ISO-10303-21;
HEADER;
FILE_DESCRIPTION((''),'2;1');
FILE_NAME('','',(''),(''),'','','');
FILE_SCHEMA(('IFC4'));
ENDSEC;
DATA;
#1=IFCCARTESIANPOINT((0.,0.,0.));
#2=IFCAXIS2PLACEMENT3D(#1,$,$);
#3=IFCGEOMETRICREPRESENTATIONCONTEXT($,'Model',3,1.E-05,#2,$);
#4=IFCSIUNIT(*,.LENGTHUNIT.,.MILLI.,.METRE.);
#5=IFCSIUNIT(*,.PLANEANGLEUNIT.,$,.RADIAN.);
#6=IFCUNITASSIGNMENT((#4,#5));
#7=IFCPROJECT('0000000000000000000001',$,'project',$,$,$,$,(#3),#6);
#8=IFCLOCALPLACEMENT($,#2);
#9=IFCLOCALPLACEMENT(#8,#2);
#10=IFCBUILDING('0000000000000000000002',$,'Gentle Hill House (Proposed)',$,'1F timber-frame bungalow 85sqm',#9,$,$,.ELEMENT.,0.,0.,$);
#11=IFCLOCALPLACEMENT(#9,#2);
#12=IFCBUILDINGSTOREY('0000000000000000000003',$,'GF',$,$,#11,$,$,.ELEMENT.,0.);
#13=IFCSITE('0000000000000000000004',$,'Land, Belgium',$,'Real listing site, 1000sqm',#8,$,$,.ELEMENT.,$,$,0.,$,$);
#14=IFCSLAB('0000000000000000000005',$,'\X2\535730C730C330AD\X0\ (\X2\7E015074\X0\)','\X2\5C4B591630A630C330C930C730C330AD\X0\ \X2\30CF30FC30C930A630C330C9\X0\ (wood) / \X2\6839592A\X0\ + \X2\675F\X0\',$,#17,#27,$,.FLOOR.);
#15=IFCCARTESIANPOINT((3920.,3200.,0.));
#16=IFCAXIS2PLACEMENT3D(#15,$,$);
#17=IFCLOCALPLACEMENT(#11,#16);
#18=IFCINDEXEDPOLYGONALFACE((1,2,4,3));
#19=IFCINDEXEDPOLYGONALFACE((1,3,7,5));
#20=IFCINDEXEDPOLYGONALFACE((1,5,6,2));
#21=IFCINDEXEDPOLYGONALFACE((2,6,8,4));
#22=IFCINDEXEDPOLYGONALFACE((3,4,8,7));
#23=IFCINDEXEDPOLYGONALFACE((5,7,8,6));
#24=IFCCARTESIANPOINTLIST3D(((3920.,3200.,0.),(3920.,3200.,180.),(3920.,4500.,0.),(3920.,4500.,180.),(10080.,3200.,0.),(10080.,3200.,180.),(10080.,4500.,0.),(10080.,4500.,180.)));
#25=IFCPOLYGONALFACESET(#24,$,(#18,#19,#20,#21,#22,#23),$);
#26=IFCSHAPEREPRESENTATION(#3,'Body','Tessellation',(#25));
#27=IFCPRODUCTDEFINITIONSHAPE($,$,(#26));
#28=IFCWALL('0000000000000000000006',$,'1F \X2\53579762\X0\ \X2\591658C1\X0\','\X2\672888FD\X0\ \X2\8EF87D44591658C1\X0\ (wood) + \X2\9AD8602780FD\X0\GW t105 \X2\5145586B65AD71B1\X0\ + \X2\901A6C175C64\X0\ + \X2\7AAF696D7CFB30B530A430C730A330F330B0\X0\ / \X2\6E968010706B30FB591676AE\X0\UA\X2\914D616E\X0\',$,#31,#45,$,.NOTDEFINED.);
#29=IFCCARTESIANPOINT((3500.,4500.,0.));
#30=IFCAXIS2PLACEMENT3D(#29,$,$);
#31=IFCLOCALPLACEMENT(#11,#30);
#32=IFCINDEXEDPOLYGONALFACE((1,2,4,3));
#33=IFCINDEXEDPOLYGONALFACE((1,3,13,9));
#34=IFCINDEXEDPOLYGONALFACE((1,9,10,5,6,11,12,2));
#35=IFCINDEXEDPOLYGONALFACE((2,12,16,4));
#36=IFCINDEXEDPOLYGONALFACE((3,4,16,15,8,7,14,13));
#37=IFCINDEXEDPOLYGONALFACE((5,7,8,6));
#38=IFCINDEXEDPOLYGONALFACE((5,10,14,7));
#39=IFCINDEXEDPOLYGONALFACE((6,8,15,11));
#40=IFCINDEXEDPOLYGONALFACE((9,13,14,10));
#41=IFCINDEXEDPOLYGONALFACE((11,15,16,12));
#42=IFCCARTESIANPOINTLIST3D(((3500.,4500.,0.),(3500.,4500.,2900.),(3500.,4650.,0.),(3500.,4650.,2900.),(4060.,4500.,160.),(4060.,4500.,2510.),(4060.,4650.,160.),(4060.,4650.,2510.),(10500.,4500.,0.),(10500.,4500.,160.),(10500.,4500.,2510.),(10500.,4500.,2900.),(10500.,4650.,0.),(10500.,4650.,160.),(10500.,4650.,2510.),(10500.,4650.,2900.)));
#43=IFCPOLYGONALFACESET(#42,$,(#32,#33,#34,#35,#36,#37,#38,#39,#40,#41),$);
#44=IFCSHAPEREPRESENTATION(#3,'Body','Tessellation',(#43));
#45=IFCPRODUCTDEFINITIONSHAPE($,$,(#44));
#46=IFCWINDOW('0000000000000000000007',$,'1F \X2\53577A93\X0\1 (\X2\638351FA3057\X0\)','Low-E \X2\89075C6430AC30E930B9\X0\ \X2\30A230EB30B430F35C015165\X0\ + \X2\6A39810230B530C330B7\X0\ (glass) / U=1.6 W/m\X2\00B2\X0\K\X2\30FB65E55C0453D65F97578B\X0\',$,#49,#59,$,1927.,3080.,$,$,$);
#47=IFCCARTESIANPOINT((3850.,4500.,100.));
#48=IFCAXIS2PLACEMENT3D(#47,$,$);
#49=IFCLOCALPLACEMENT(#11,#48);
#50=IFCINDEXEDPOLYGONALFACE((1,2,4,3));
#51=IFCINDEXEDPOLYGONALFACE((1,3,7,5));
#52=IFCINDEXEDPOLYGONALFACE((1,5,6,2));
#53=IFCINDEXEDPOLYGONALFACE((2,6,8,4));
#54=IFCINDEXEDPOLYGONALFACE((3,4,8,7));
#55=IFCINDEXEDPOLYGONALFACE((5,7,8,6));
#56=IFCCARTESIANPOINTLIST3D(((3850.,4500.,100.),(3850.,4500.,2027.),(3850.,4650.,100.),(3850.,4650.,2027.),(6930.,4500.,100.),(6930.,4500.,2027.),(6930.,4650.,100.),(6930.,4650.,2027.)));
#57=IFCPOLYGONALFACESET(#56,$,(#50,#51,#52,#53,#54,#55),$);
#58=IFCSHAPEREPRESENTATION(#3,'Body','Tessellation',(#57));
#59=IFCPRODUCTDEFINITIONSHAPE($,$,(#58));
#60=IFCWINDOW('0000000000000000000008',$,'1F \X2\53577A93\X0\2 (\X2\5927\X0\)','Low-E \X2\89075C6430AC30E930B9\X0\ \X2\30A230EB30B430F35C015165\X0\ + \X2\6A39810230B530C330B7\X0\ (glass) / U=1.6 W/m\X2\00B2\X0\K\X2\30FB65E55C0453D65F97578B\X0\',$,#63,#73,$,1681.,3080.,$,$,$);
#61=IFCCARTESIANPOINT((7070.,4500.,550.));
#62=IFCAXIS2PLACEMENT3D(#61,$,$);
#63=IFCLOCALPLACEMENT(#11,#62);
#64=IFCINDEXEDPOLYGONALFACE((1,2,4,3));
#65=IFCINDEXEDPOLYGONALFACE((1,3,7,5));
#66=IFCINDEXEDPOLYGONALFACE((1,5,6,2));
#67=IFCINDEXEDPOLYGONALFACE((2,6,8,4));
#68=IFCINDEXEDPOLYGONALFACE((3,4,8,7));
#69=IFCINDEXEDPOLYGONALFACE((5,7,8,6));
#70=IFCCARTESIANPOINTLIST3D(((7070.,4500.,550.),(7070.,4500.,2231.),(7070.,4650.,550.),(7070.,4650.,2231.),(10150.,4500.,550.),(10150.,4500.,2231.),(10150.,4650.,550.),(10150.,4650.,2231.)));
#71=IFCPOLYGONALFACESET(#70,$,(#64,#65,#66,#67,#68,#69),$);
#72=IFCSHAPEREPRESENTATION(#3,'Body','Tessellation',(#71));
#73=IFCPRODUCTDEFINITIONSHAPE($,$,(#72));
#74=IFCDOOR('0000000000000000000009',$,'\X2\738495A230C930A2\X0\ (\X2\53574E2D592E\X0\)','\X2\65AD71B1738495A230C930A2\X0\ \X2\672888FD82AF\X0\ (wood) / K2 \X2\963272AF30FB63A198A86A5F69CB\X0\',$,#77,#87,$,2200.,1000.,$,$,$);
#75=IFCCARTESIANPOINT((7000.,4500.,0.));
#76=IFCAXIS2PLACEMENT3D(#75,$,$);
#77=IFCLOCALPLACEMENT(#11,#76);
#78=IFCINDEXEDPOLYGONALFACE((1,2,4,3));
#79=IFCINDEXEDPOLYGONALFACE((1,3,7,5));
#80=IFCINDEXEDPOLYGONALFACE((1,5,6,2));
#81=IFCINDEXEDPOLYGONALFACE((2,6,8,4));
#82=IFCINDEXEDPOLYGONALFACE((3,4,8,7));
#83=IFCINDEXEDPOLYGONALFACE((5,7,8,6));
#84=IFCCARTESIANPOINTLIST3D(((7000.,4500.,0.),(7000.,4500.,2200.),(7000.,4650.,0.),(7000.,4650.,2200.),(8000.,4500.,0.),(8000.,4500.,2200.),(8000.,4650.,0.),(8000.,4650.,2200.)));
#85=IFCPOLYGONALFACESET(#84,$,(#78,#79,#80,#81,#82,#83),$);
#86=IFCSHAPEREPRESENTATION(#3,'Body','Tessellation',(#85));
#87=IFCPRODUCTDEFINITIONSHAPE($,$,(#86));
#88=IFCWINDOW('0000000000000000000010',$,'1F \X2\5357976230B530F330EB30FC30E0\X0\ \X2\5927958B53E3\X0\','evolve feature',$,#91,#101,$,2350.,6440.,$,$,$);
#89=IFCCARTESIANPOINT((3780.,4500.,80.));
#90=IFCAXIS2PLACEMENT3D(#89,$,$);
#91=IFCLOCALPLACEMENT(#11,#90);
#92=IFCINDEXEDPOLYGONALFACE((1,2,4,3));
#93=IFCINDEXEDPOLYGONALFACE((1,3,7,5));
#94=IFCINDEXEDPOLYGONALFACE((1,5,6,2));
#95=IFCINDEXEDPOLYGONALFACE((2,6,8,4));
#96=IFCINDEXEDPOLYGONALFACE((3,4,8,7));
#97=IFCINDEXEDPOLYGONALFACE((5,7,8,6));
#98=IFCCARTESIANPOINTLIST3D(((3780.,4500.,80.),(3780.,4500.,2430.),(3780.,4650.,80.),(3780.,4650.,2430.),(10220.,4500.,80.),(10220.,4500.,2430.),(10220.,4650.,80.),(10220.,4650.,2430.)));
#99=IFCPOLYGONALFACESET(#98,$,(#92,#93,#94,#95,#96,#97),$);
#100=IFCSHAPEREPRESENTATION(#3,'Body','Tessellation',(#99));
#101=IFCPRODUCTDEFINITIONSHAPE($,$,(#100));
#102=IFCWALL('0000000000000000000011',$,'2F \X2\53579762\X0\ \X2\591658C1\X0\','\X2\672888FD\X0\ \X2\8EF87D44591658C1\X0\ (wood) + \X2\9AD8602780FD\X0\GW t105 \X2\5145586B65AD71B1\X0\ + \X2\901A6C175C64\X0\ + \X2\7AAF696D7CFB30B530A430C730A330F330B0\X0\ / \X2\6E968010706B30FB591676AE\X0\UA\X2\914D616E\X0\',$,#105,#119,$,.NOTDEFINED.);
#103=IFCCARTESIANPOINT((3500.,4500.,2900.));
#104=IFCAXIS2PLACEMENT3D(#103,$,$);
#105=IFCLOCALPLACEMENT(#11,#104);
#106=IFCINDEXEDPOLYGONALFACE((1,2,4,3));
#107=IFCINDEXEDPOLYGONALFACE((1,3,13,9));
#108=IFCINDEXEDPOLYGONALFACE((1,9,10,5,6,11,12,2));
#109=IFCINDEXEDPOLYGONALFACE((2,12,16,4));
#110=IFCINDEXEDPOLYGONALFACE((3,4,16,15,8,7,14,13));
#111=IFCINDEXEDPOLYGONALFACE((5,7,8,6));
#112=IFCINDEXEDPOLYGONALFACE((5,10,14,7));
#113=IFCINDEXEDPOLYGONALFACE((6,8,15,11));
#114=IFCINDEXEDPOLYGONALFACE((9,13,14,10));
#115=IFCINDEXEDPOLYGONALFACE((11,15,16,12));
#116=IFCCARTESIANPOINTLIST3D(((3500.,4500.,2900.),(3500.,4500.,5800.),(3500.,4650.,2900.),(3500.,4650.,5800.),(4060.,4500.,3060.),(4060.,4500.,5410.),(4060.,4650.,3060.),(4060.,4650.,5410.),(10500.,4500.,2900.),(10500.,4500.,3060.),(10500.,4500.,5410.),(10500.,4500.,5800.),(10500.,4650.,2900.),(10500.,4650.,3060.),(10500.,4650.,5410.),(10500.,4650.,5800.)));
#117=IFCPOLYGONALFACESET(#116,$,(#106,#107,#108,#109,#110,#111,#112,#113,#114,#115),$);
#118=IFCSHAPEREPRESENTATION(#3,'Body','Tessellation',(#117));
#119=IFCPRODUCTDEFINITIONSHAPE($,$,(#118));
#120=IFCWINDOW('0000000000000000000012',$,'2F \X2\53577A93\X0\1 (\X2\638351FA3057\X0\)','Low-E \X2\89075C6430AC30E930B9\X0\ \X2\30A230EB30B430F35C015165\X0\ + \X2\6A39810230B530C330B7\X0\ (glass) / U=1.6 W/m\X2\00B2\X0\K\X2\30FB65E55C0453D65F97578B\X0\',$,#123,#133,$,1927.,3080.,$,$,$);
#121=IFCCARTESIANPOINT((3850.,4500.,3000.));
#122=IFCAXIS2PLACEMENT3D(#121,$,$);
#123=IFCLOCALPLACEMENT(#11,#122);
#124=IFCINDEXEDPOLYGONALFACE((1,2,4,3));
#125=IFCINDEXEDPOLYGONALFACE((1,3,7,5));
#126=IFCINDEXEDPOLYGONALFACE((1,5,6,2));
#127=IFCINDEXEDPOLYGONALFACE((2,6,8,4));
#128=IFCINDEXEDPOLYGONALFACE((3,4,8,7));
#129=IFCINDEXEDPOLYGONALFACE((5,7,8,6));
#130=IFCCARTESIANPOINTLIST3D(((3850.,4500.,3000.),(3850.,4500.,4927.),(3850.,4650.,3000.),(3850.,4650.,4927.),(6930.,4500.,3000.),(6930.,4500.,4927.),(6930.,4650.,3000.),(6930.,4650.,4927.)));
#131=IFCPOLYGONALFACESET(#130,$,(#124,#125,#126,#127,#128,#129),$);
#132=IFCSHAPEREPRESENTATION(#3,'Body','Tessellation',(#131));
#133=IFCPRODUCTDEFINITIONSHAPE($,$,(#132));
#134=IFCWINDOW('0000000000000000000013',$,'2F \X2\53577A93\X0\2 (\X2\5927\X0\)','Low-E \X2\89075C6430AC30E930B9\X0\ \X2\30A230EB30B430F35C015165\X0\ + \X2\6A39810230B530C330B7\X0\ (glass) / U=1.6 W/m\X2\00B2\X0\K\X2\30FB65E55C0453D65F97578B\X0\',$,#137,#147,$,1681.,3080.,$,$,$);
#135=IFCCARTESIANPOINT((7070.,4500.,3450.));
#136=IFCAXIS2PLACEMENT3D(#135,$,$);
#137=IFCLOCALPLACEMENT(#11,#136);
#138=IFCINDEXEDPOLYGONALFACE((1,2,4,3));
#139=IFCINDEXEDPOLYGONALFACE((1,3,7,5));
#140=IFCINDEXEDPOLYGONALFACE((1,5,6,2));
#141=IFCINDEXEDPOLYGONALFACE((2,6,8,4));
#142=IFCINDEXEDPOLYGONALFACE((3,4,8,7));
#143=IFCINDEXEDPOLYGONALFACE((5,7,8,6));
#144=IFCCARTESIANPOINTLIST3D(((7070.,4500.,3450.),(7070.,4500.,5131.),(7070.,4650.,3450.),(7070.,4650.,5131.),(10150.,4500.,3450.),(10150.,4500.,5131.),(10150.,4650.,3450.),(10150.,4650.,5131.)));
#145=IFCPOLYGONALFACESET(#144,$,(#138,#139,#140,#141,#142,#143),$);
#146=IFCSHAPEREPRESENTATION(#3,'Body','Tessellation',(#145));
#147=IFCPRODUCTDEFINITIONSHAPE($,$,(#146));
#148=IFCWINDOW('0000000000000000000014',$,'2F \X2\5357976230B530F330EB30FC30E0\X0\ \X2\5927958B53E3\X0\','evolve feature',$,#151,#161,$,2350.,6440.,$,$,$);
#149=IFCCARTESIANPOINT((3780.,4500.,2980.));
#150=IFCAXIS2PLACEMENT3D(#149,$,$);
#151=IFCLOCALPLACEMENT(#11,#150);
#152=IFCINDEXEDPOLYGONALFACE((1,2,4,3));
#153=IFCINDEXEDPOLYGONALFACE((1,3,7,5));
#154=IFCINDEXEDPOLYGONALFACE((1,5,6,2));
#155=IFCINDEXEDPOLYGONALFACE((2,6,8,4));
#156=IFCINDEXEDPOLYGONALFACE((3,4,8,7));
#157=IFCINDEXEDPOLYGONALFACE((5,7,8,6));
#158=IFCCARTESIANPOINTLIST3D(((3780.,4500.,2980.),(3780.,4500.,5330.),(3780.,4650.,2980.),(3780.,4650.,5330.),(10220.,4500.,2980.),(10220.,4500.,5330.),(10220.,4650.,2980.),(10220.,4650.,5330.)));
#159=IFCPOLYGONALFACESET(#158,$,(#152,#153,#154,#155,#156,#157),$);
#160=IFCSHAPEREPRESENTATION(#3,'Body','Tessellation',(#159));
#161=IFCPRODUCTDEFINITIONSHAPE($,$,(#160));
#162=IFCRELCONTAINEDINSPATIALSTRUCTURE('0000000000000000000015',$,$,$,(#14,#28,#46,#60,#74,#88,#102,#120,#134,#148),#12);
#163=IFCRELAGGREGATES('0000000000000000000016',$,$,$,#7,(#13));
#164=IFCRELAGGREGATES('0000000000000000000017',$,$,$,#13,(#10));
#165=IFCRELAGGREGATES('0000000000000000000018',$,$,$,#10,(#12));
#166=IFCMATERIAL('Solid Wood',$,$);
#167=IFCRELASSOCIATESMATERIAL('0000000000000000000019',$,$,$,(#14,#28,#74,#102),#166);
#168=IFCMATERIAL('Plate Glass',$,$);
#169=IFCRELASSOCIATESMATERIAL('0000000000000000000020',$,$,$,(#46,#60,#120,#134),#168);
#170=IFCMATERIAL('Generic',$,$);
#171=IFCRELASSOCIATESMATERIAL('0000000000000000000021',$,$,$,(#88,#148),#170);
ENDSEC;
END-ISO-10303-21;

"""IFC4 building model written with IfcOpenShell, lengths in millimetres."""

from ifc_helpers import new_model, si_unit, frame, frame_2d, origin, place, context, project, spatial, rectangle, extrude, material, element, fill, save


model = new_model("IFC4")

# Units and contexts
model_context = context("Model", 3, precision=1e-05, world=origin())
ifc_project = project(units=[si_unit("LENGTHUNIT", "METRE", prefix="MILLI"), si_unit("PLANEANGLEUNIT", "RADIAN")], contexts=[model_context])

# Site, building, storey
site_placement = place(None, origin())
site = spatial("IfcSite", under=ifc_project, at=site_placement, Name="Land, Belgium", ObjectType="Real listing site, 1000sqm", CompositionType="ELEMENT", RefElevation=0.0)
building_placement = place(site_placement, origin())
building = spatial("IfcBuilding", under=site, at=building_placement, Name="Gentle Hill House (Proposed)", ObjectType="1F timber-frame bungalow 85sqm", CompositionType="ELEMENT", ElevationOfRefHeight=0.0, ElevationOfTerrain=0.0)
storey_placement = place(building_placement, origin())
storey = spatial("IfcBuildingStorey", under=building, at=storey_placement, Name="GF", CompositionType="ELEMENT", Elevation=0.0)

# Slab
ifc_material_1 = material(Name="Solid Wood")
slab_1_placement = place(storey_placement, frame((3920.0, 3200.0, 0.0)))
element("IfcSlab", 1, at=slab_1_placement, inside=storey, material=ifc_material_1, Name="南デッキ (縁側)", Description="屋外ウッドデッキ ハードウッド (wood) / 根太 + 束", PredefinedType="FLOOR", context=model_context, shape_type="SweptSolid", body=[
    extrude(rectangle(XDim=6160.0, YDim=1300.0, at=frame_2d((3080.0, 650.0))), frame((3920.0, 3200.0, 0.0)), (0.0, 0.0, 1.0), 180.0),
])
ifc_material_2 = material(Name="Generic")

# Wall, openings, windows, door
wall_1_placement = place(storey_placement, frame((3500.0, 4500.0, 0.0)))
wall_1 = element("IfcWall", 2, at=wall_1_placement, inside=storey, material=ifc_material_1, Name="1F 南面 外壁", Description="木製 軸組外壁 (wood) + 高性能GW t105 充填断熱 + 通気層 + 窯業系サイディング / 準耐火・外皮UA配慮", PredefinedType="NOTDEFINED", context=model_context, shape_type="SweptSolid", body=[
    extrude(rectangle(XDim=7000.0, YDim=150.0, at=frame_2d((3500.0, 75.0))), frame((3500.0, 4500.0, 0.0)), (0.0, 0.0, 1.0), 2900.0),
])
opening_1_placement = place(storey_placement, frame((3850.0, 4500.0, 100.0)))
opening_1 = element("IfcOpeningElement", 3, at=opening_1_placement, cuts=wall_1, PredefinedType="NOTDEFINED", context=model_context, shape_type="SweptSolid", body=[
    extrude(rectangle(XDim=3080.0, YDim=150.0, at=frame_2d((1540.0, 75.0))), frame((3850.0, 4500.0, 100.0)), (0.0, 0.0, 1.0), 1927.0),
])
opening_2_placement = place(storey_placement, frame((7070.0, 4500.0, 550.0)))
opening_2 = element("IfcOpeningElement", 4, at=opening_2_placement, cuts=wall_1, PredefinedType="NOTDEFINED", context=model_context, shape_type="SweptSolid", body=[
    extrude(rectangle(XDim=3080.0, YDim=150.0, at=frame_2d((1540.0, 75.0))), frame((7070.0, 4500.0, 550.0)), (0.0, 0.0, 1.0), 1681.0),
])
opening_3_placement = place(storey_placement, frame((7000.0, 4500.0, 0.0)))
opening_3 = element("IfcOpeningElement", 5, at=opening_3_placement, cuts=wall_1, PredefinedType="NOTDEFINED", context=model_context, shape_type="SweptSolid", body=[
    extrude(rectangle(XDim=1000.0, YDim=150.0, at=frame_2d((500.0, 75.0))), frame((7000.0, 4500.0, 0.0)), (0.0, 0.0, 1.0), 2200.0),
])
opening_4_placement = place(storey_placement, frame((3780.0, 4500.0, 80.0)))
opening_4 = element("IfcOpeningElement", 6, at=opening_4_placement, cuts=wall_1, PredefinedType="NOTDEFINED", context=model_context, shape_type="SweptSolid", body=[
    extrude(rectangle(XDim=6440.0, YDim=150.0, at=frame_2d((3220.0, 75.0))), frame((3780.0, 4500.0, 80.0)), (0.0, 0.0, 1.0), 2350.0),
])
ifc_material_3 = material(Name="Plate Glass")
window_1_placement = place(storey_placement, frame((3850.0, 4500.0, 100.0)))
window_1 = element("IfcWindow", 7, at=window_1_placement, inside=storey, material=ifc_material_3, Name="1F 南窓1 (掃出し)", Description="Low-E 複層ガラス アルゴン封入 + 樹脂サッシ (glass) / U=1.6 W/m²K・日射取得型", OverallHeight=1927.0, OverallWidth=3080.0, context=model_context, shape_type="SweptSolid", body=[
    extrude(rectangle(XDim=3080.0, YDim=150.0, at=frame_2d((1540.0, 75.0))), frame((3850.0, 4500.0, 100.0)), (0.0, 0.0, 1.0), 1927.0),
])
fill(opening_1, window_1)
window_2_placement = place(storey_placement, frame((7070.0, 4500.0, 550.0)))
window_2 = element("IfcWindow", 8, at=window_2_placement, inside=storey, material=ifc_material_3, Name="1F 南窓2 (大)", Description="Low-E 複層ガラス アルゴン封入 + 樹脂サッシ (glass) / U=1.6 W/m²K・日射取得型", OverallHeight=1681.0, OverallWidth=3080.0, context=model_context, shape_type="SweptSolid", body=[
    extrude(rectangle(XDim=3080.0, YDim=150.0, at=frame_2d((1540.0, 75.0))), frame((7070.0, 4500.0, 550.0)), (0.0, 0.0, 1.0), 1681.0),
])
fill(opening_2, window_2)
door_placement = place(storey_placement, frame((7000.0, 4500.0, 0.0)))
door = element("IfcDoor", 9, at=door_placement, inside=storey, material=ifc_material_1, Name="玄関ドア (南中央)", Description="断熱玄関ドア 木製芯 (wood) / K2 防犯・採風機構", OverallHeight=2200.0, OverallWidth=1000.0, context=model_context, shape_type="SweptSolid", body=[
    extrude(rectangle(XDim=1000.0, YDim=150.0, at=frame_2d((500.0, 75.0))), frame((7000.0, 4500.0, 0.0)), (0.0, 0.0, 1.0), 2200.0),
])
fill(opening_3, door)
window_3_placement = place(storey_placement, frame((3780.0, 4500.0, 80.0)))
window_3 = element("IfcWindow", 10, at=window_3_placement, inside=storey, material=ifc_material_2, Name="1F 南面サンルーム 大開口", Description="evolve feature", OverallHeight=2350.0, OverallWidth=6440.0, context=model_context, shape_type="SweptSolid", body=[
    extrude(rectangle(XDim=6440.0, YDim=150.0, at=frame_2d((3220.0, 75.0))), frame((3780.0, 4500.0, 80.0)), (0.0, 0.0, 1.0), 2350.0),
])
fill(opening_4, window_3)

# Wall, openings, windows
wall_2_placement = place(storey_placement, frame((3500.0, 4500.0, 2900.0)))
wall_2 = element("IfcWall", 11, at=wall_2_placement, inside=storey, material=ifc_material_1, Name="2F 南面 外壁", Description="木製 軸組外壁 (wood) + 高性能GW t105 充填断熱 + 通気層 + 窯業系サイディング / 準耐火・外皮UA配慮", PredefinedType="NOTDEFINED", context=model_context, shape_type="SweptSolid", body=[
    extrude(rectangle(XDim=7000.0, YDim=150.0, at=frame_2d((3500.0, 75.0))), frame((3500.0, 4500.0, 2900.0)), (0.0, 0.0, 1.0), 2900.0),
])
opening_5_placement = place(storey_placement, frame((3850.0, 4500.0, 3000.0)))
opening_5 = element("IfcOpeningElement", 12, at=opening_5_placement, cuts=wall_2, PredefinedType="NOTDEFINED", context=model_context, shape_type="SweptSolid", body=[
    extrude(rectangle(XDim=3080.0, YDim=150.0, at=frame_2d((1540.0, 75.0))), frame((3850.0, 4500.0, 3000.0)), (0.0, 0.0, 1.0), 1927.0),
])
opening_6_placement = place(storey_placement, frame((7070.0, 4500.0, 3450.0)))
opening_6 = element("IfcOpeningElement", 13, at=opening_6_placement, cuts=wall_2, PredefinedType="NOTDEFINED", context=model_context, shape_type="SweptSolid", body=[
    extrude(rectangle(XDim=3080.0, YDim=150.0, at=frame_2d((1540.0, 75.0))), frame((7070.0, 4500.0, 3450.0)), (0.0, 0.0, 1.0), 1681.0),
])
opening_7_placement = place(storey_placement, frame((3780.0, 4500.0, 2980.0)))
opening_7 = element("IfcOpeningElement", 14, at=opening_7_placement, cuts=wall_2, PredefinedType="NOTDEFINED", context=model_context, shape_type="SweptSolid", body=[
    extrude(rectangle(XDim=6440.0, YDim=150.0, at=frame_2d((3220.0, 75.0))), frame((3780.0, 4500.0, 2980.0)), (0.0, 0.0, 1.0), 2350.0),
])
window_4_placement = place(storey_placement, frame((3850.0, 4500.0, 3000.0)))
window_4 = element("IfcWindow", 15, at=window_4_placement, inside=storey, material=ifc_material_3, Name="2F 南窓1 (掃出し)", Description="Low-E 複層ガラス アルゴン封入 + 樹脂サッシ (glass) / U=1.6 W/m²K・日射取得型", OverallHeight=1927.0, OverallWidth=3080.0, context=model_context, shape_type="SweptSolid", body=[
    extrude(rectangle(XDim=3080.0, YDim=150.0, at=frame_2d((1540.0, 75.0))), frame((3850.0, 4500.0, 3000.0)), (0.0, 0.0, 1.0), 1927.0),
])
fill(opening_5, window_4)
window_5_placement = place(storey_placement, frame((7070.0, 4500.0, 3450.0)))
window_5 = element("IfcWindow", 16, at=window_5_placement, inside=storey, material=ifc_material_3, Name="2F 南窓2 (大)", Description="Low-E 複層ガラス アルゴン封入 + 樹脂サッシ (glass) / U=1.6 W/m²K・日射取得型", OverallHeight=1681.0, OverallWidth=3080.0, context=model_context, shape_type="SweptSolid", body=[
    extrude(rectangle(XDim=3080.0, YDim=150.0, at=frame_2d((1540.0, 75.0))), frame((7070.0, 4500.0, 3450.0)), (0.0, 0.0, 1.0), 1681.0),
])
fill(opening_6, window_5)
window_6_placement = place(storey_placement, frame((3780.0, 4500.0, 2980.0)))
window_6 = element("IfcWindow", 17, at=window_6_placement, inside=storey, material=ifc_material_2, Name="2F 南面サンルーム 大開口", Description="evolve feature", OverallHeight=2350.0, OverallWidth=6440.0, context=model_context, shape_type="SweptSolid", body=[
    extrude(rectangle(XDim=6440.0, YDim=150.0, at=frame_2d((3220.0, 75.0))), frame((3780.0, 4500.0, 2980.0)), (0.0, 0.0, 1.0), 2350.0),
])
fill(opening_7, window_6)

save(model, "model.ifc")
